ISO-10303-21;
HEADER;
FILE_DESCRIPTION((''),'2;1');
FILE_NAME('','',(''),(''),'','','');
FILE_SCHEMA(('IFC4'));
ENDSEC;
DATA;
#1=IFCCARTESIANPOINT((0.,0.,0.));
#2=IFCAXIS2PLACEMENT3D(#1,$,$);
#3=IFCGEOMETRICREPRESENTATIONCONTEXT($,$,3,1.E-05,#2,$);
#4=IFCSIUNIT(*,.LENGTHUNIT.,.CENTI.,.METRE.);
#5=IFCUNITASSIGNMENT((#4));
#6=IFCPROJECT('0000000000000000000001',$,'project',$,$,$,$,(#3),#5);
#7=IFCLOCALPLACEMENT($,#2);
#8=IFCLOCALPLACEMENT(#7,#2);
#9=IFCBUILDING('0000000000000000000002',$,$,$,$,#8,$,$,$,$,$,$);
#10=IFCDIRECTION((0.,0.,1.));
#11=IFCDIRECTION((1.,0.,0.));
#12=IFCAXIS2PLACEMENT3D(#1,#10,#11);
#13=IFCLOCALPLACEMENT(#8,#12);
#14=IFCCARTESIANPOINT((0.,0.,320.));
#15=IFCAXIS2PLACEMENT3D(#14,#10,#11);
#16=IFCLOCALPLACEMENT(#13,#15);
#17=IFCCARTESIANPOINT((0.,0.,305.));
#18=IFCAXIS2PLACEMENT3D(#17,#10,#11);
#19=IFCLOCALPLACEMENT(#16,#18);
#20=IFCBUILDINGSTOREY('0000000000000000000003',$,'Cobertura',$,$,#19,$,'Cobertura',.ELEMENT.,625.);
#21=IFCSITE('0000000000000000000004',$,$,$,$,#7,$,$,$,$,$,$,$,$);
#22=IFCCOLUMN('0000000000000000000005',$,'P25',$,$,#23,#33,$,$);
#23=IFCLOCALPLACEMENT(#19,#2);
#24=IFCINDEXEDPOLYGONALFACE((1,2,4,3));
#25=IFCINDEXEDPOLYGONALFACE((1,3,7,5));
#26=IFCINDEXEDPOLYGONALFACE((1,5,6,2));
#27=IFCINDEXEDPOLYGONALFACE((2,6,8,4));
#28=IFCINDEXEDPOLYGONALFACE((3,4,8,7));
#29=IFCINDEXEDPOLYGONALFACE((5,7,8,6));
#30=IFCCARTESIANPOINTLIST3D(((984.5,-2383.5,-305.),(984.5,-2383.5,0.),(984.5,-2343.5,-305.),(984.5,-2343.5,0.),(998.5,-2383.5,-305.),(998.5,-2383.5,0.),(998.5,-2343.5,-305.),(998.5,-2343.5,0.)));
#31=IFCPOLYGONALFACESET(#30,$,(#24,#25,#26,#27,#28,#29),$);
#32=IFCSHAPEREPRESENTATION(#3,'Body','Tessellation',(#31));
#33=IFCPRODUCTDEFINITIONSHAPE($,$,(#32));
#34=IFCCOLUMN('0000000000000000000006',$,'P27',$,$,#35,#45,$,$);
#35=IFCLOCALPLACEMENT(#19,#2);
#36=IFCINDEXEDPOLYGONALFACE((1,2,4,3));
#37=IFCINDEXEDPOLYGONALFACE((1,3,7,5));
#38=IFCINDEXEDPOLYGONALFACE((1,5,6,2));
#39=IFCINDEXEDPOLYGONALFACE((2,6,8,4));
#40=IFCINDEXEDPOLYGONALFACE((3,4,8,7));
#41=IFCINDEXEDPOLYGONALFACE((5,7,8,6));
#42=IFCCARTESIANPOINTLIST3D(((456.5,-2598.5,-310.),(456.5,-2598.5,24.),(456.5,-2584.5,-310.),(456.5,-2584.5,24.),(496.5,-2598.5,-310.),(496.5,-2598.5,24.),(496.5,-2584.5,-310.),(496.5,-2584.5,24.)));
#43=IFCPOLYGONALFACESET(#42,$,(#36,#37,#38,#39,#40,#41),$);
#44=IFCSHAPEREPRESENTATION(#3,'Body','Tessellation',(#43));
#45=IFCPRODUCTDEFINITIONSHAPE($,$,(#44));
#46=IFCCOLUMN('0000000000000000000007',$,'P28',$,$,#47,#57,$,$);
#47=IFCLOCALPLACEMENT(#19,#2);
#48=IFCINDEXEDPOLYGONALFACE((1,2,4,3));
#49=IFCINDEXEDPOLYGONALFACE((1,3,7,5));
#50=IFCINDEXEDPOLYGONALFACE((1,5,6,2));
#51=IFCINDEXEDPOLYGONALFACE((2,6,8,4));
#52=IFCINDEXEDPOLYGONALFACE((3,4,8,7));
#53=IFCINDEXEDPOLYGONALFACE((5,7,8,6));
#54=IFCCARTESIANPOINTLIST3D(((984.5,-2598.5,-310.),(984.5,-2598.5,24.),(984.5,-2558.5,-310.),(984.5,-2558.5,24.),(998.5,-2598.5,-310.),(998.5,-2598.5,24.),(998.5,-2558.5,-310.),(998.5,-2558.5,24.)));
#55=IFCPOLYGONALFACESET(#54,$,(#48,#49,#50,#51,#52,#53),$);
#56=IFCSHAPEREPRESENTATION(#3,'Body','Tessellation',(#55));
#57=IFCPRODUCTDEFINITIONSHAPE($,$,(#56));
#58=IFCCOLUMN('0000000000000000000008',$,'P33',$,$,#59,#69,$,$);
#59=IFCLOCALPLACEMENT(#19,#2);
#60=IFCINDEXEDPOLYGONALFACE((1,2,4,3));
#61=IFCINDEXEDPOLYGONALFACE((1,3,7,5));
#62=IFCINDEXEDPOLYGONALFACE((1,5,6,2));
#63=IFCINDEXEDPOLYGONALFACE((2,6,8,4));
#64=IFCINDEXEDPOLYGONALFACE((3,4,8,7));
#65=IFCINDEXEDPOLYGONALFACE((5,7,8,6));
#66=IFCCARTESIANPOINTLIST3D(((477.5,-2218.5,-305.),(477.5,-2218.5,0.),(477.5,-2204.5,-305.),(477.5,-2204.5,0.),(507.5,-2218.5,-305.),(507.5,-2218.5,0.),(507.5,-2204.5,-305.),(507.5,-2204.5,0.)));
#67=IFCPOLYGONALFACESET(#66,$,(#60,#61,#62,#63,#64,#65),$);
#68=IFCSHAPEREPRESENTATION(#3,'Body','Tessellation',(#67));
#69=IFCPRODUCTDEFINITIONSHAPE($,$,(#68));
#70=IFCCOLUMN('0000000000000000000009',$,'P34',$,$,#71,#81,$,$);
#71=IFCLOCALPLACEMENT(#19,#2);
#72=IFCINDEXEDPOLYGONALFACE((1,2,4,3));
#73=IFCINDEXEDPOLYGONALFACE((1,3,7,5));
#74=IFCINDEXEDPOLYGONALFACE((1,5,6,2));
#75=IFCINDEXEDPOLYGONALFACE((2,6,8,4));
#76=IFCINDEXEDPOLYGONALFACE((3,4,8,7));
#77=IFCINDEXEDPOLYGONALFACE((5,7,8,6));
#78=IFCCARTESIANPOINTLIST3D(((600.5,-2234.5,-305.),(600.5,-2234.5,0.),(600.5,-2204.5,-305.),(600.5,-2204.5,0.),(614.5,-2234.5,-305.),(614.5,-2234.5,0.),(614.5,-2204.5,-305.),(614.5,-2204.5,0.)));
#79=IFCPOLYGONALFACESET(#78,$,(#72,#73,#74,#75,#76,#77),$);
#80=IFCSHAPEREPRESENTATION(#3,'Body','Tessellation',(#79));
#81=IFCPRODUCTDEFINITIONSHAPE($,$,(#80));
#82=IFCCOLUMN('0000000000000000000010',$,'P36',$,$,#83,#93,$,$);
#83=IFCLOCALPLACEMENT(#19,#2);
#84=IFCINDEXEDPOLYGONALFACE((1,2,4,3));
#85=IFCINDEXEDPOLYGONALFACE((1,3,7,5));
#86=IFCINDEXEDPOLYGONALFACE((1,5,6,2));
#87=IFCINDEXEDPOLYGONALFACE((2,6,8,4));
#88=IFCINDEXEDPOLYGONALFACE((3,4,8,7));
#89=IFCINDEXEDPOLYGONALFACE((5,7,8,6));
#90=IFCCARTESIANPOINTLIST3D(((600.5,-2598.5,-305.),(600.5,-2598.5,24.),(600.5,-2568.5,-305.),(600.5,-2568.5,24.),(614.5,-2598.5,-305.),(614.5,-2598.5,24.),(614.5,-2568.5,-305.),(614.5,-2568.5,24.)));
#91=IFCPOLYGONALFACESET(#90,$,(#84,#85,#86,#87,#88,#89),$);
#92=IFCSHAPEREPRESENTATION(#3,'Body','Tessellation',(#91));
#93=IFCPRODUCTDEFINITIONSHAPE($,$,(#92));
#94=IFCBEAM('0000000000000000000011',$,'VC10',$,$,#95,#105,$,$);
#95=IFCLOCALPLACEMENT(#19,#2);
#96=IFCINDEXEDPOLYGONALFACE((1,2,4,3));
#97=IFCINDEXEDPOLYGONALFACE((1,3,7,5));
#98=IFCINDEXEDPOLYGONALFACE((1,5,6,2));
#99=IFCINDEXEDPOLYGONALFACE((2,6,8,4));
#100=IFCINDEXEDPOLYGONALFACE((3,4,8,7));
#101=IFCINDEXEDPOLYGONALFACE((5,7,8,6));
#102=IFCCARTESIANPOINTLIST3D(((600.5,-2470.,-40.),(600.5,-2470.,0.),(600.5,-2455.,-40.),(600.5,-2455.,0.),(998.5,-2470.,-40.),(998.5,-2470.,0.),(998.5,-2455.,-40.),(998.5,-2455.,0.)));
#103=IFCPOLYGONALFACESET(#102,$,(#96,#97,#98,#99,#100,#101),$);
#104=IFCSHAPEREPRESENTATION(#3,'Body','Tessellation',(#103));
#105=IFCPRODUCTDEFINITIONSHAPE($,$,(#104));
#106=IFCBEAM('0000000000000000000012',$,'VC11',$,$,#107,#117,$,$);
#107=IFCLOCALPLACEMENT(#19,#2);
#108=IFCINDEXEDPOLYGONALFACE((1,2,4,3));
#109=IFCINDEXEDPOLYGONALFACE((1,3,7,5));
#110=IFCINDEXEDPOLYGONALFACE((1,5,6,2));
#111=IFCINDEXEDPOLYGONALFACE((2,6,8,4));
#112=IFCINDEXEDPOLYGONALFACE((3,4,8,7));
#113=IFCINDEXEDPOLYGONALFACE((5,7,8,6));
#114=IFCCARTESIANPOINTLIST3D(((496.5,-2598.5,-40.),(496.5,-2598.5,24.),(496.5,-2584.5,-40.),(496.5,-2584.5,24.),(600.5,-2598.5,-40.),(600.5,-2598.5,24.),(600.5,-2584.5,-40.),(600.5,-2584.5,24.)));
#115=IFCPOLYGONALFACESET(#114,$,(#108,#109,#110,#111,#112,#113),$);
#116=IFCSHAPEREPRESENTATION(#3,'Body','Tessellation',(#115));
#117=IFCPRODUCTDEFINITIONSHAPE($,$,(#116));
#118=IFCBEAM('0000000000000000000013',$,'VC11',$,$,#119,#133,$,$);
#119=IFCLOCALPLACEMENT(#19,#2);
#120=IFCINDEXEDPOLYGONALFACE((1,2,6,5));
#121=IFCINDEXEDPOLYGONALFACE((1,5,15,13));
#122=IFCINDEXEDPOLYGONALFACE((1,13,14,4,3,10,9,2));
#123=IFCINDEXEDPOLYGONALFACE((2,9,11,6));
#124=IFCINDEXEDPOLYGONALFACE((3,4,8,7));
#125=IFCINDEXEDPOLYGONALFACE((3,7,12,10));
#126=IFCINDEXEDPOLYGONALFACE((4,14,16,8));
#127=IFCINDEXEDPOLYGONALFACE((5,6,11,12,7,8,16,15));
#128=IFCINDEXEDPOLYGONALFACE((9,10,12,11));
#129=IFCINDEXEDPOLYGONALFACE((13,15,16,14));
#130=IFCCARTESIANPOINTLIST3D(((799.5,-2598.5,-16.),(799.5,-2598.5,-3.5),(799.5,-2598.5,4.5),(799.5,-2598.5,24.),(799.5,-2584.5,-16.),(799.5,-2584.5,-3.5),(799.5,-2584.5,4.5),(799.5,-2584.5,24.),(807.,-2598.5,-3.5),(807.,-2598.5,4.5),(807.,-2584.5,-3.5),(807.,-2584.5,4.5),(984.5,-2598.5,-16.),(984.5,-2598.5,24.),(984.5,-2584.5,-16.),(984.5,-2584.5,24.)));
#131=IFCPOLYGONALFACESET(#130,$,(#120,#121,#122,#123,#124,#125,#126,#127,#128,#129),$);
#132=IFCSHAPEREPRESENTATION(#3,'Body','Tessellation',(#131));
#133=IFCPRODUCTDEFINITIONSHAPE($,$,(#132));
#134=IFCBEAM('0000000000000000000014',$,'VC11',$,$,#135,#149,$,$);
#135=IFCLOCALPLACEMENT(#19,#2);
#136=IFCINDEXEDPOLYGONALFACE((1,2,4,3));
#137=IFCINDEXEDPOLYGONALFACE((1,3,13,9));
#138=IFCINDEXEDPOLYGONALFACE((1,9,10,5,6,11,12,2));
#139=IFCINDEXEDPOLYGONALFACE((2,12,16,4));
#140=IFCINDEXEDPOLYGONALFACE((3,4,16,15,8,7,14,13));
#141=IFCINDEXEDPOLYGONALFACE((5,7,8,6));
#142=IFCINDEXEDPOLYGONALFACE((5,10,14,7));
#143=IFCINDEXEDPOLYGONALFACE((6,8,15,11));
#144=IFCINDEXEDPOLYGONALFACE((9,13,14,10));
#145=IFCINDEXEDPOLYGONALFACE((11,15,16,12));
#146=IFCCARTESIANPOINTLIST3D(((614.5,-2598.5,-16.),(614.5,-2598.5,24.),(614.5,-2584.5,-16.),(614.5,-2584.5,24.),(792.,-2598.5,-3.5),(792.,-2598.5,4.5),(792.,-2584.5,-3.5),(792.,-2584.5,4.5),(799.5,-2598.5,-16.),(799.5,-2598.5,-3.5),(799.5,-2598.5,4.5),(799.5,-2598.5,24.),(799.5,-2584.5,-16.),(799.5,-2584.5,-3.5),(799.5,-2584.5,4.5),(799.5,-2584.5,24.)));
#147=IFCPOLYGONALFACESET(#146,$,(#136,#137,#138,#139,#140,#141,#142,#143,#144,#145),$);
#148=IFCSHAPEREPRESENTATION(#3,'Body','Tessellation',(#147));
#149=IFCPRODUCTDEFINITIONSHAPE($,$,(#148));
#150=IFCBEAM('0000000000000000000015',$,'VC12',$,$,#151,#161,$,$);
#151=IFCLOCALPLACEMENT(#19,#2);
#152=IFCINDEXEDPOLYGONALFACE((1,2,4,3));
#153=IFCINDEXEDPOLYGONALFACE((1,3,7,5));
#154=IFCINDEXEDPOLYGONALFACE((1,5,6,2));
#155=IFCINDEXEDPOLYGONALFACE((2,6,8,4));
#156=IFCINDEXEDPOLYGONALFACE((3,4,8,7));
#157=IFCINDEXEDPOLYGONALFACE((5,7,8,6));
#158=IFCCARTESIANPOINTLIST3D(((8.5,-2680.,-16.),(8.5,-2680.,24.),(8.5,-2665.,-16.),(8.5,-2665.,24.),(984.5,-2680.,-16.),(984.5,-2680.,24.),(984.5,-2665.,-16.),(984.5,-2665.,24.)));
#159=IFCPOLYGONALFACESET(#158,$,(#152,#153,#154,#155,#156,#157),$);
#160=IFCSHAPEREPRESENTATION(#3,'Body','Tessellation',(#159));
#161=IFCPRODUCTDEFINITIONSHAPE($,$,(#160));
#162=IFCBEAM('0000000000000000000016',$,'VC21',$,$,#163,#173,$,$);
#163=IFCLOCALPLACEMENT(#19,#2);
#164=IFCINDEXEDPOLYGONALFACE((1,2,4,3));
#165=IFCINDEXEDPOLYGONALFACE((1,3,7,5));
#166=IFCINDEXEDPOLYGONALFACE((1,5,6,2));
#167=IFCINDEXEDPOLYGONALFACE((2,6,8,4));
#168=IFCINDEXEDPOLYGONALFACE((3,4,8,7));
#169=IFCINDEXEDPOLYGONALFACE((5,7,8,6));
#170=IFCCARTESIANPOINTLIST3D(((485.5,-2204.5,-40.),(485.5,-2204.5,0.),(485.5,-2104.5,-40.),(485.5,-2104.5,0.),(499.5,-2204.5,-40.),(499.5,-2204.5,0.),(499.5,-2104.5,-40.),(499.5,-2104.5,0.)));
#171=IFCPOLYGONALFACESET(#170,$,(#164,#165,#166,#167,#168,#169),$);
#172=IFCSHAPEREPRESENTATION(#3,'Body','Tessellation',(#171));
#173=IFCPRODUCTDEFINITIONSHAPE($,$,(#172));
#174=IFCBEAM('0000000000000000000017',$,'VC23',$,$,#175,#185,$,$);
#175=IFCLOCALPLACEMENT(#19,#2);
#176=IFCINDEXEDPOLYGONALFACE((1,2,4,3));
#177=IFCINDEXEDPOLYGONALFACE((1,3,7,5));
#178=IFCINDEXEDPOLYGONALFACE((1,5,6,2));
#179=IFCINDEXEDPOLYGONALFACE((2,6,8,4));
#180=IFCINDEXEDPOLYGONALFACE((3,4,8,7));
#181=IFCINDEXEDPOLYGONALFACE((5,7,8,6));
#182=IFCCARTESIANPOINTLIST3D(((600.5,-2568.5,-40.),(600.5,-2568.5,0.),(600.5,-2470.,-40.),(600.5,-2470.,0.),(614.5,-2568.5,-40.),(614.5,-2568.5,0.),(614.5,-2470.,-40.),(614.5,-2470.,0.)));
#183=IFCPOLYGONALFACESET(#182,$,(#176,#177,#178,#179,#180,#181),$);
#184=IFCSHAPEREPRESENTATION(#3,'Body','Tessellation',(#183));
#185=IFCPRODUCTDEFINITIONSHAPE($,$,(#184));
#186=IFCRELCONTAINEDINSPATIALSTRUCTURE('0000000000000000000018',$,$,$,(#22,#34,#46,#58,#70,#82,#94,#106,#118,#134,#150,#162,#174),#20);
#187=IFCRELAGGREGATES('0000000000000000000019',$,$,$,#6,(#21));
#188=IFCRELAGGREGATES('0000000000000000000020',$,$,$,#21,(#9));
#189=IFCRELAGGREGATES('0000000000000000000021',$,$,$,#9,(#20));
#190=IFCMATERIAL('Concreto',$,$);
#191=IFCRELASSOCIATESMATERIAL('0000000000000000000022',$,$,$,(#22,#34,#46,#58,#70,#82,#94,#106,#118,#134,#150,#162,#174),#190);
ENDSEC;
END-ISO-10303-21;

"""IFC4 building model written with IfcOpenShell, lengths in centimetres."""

from ifc_helpers import new_model, si_unit, frame, origin, origin_with_axes, place, context, project, spatial, polyline, outline, extrude, material, element, save


model = new_model("IFC4")

# Units and contexts
context_of_model = context(None, 3, precision=1e-05, world=origin())
ifc_project = project(units=[si_unit("LENGTHUNIT", "METRE", prefix="CENTI")], contexts=[context_of_model])

# Site, building, storey
site_placement = place(None, origin())
site = spatial("IfcSite", under=ifc_project, at=site_placement)
building_placement = place(site_placement, origin())
building = spatial("IfcBuilding", under=site, at=building_placement)
placement_1 = place(building_placement, origin_with_axes())
placement_2 = place(placement_1, frame((0.0, 0.0, 320.0), z_axis=(0.0, 0.0, 1.0), x_axis=(1.0, 0.0, 0.0)))
storey_placement = place(placement_2, frame((0.0, 0.0, 305.0), z_axis=(0.0, 0.0, 1.0), x_axis=(1.0, 0.0, 0.0)))
storey = spatial("IfcBuildingStorey", under=building, at=storey_placement, Name="Cobertura", LongName="Cobertura", CompositionType="ELEMENT", Elevation=625.0)

# Columns
ifc_material = material(Name="Concreto")
column_1_placement = place(storey_placement, frame((991.5, -2363.5, 0.0), z_axis=(0.0, 0.0, 1.0), x_axis=(1.0, 0.0, 0.0)))
element("IfcColumn", 1, at=column_1_placement, inside=storey, material=ifc_material, Name="P25", context=context_of_model, shape_type="SolidModel", body=[
    extrude(outline(polyline([(7.0, 20.0), (-7.0, 20.0), (-7.0, -20.0), (7.0, -20.0), (7.0, 20.0)])), origin_with_axes(), (0.0, 0.0, -1.0), 305.0),
])
column_2_placement = place(storey_placement, frame((476.5, -2591.5, 24.0), z_axis=(0.0, 0.0, 1.0), x_axis=(1.0, 0.0, 0.0)))
element("IfcColumn", 2, at=column_2_placement, inside=storey, material=ifc_material, Name="P27", context=context_of_model, shape_type="SolidModel", body=[
    extrude(outline(polyline([(20.0, -7.0), (20.0, 7.0), (-20.0, 7.0), (-20.0, -7.0), (20.0, -7.0)])), origin_with_axes(), (0.0, 0.0, -1.0), 334.0),
])
column_3_placement = place(storey_placement, frame((991.5, -2578.5, 24.0), z_axis=(0.0, 0.0, 1.0), x_axis=(1.0, 0.0, 0.0)))
element("IfcColumn", 3, at=column_3_placement, inside=storey, material=ifc_material, Name="P28", context=context_of_model, shape_type="SolidModel", body=[
    extrude(outline(polyline([(7.0, 20.0), (-7.0, 20.0), (-7.0, -20.0), (7.0, -20.0), (7.0, 20.0)])), origin_with_axes(), (0.0, 0.0, -1.0), 334.0),
])
column_4_placement = place(storey_placement, frame((492.5, -2211.5, 0.0), z_axis=(0.0, 0.0, 1.0), x_axis=(1.0, 0.0, 0.0)))
element("IfcColumn", 4, at=column_4_placement, inside=storey, material=ifc_material, Name="P33", context=context_of_model, shape_type="SolidModel", body=[
    extrude(outline(polyline([(15.0, -7.0), (15.0, 7.0), (-15.0, 7.0), (-15.0, -7.0), (15.0, -7.0)])), origin_with_axes(), (0.0, 0.0, -1.0), 305.0),
])
column_5_placement = place(storey_placement, frame((607.5, -2219.5, 0.0), z_axis=(0.0, 0.0, 1.0), x_axis=(1.0, 0.0, 0.0)))
element("IfcColumn", 5, at=column_5_placement, inside=storey, material=ifc_material, Name="P34", context=context_of_model, shape_type="SolidModel", body=[
    extrude(outline(polyline([(7.0, 15.0), (-7.0, 15.0), (-7.0, -15.0), (7.0, -15.0), (7.0, 15.0)])), origin_with_axes(), (0.0, 0.0, -1.0), 305.0),
])
column_6_placement = place(storey_placement, frame((607.5, -2583.5, 24.0), z_axis=(0.0, 0.0, 1.0), x_axis=(1.0, 0.0, 0.0)))
element("IfcColumn", 6, at=column_6_placement, inside=storey, material=ifc_material, Name="P36", context=context_of_model, shape_type="SolidModel", body=[
    extrude(outline(polyline([(7.0, 15.0), (-7.0, 15.0), (-7.0, -15.0), (7.0, -15.0), (7.0, 15.0)])), origin_with_axes(), (0.0, 0.0, -1.0), 329.0),
])

# Beams
beam_1_placement = place(storey_placement, frame((799.5, -2462.5, 0.0), z_axis=(0.0, 0.0, 1.0), x_axis=(1.0, 0.0, 0.0)))
element("IfcBeam", 7, at=beam_1_placement, inside=storey, material=ifc_material, Name="VC10", context=context_of_model, shape_type="SolidModel", body=[
    extrude(outline(polyline([(-7.5, -20.0), (7.5, -20.0), (7.5, 20.0), (-7.5, 20.0), (-7.5, -20.0)])), frame((-199.0, 0.0, -20.0), z_axis=(1.0, 0.0, 0.0), x_axis=(0.0, -1.0, 0.0)), (0.0, 0.0, 1.0), 398.0),
])
beam_2_placement = place(storey_placement, frame((548.5, -2591.5, 24.0), z_axis=(0.0, 0.0, 1.0), x_axis=(1.0, 0.0, 0.0)))
element("IfcBeam", 8, at=beam_2_placement, inside=storey, material=ifc_material, Name="VC11", context=context_of_model, shape_type="SolidModel", body=[
    extrude(outline(polyline([(-7.0, -32.0), (7.0, -32.0), (7.0, 32.0), (-7.0, 32.0), (-7.0, -32.0)])), frame((-52.0, 0.0, -32.0), z_axis=(1.0, 0.0, 0.0), x_axis=(0.0, -1.0, 0.0)), (0.0, 0.0, 1.0), 104.0),
])

# Beams, openings
beam_3_placement = place(storey_placement, frame((892.0, -2591.5, 24.0), z_axis=(0.0, 0.0, 1.0), x_axis=(1.0, 0.0, 0.0)))
beam_3 = element("IfcBeam", 9, at=beam_3_placement, inside=storey, material=ifc_material, Name="VC11", context=context_of_model, shape_type="SolidModel", body=[
    extrude(outline(polyline([(-7.0, -20.0), (7.0, -20.0), (7.0, 20.0), (-7.0, 20.0), (-7.0, -20.0)])), frame((-92.5, 0.0, -20.0), z_axis=(1.0, 0.0, 0.0), x_axis=(0.0, -1.0, 0.0)), (0.0, 0.0, 1.0), 185.0),
])
opening_1_placement = place(storey_placement, frame((0.0, 0.0, -625.0), z_axis=(0.0, 0.0, 1.0), x_axis=(1.0, 0.0, 0.0)))
element("IfcOpeningElement", 10, at=opening_1_placement, cuts=beam_3, material=ifc_material, context=context_of_model, shape_type="SweptSolid", body=[
    extrude(outline(polyline([(7.5, 4.0), (-7.5, 4.0), (-7.5, -4.0), (7.5, -4.0), (7.5, 4.0)])), frame((799.5, -2598.5, 625.5), z_axis=(0.0, 1.0, 0.0), x_axis=(-1.0, 0.0, 0.0)), (0.0, 0.0, 1.0), 14.0),
])
beam_4_placement = place(storey_placement, frame((707.0, -2591.5, 24.0), z_axis=(0.0, 0.0, 1.0), x_axis=(1.0, 0.0, 0.0)))
beam_4 = element("IfcBeam", 11, at=beam_4_placement, inside=storey, material=ifc_material, Name="VC11", context=context_of_model, shape_type="SolidModel", body=[
    extrude(outline(polyline([(-7.0, -20.0), (7.0, -20.0), (7.0, 20.0), (-7.0, 20.0), (-7.0, -20.0)])), frame((-92.5, 0.0, -20.0), z_axis=(1.0, 0.0, 0.0), x_axis=(0.0, -1.0, 0.0)), (0.0, 0.0, 1.0), 185.0),
])
opening_2_placement = place(storey_placement, frame((0.0, 0.0, -625.0), z_axis=(0.0, 0.0, 1.0), x_axis=(1.0, 0.0, 0.0)))
element("IfcOpeningElement", 12, at=opening_2_placement, cuts=beam_4, material=ifc_material, context=context_of_model, shape_type="SweptSolid", body=[
    extrude(outline(polyline([(7.5, 4.0), (-7.5, 4.0), (-7.5, -4.0), (7.5, -4.0), (7.5, 4.0)])), frame((799.5, -2598.5, 625.5), z_axis=(0.0, 1.0, 0.0), x_axis=(-1.0, 0.0, 0.0)), (0.0, 0.0, 1.0), 14.0),
])

# Beams
beam_5_placement = place(storey_placement, frame((496.5, -2672.5, 24.0), z_axis=(0.0, 0.0, 1.0), x_axis=(1.0, 0.0, 0.0)))
element("IfcBeam", 13, at=beam_5_placement, inside=storey, material=ifc_material, Name="VC12", context=context_of_model, shape_type="SolidModel", body=[
    extrude(outline(polyline([(-7.5, -20.0), (7.5, -20.0), (7.5, 20.0), (-7.5, 20.0), (-7.5, -20.0)])), frame((-488.0, 0.0, -20.0), z_axis=(1.0, 0.0, 0.0), x_axis=(0.0, -1.0, 0.0)), (0.0, 0.0, 1.0), 976.0),
])
beam_6_placement = place(storey_placement, frame((492.5, -2154.5, 0.0), z_axis=(0.0, 0.0, 1.0), x_axis=(1.0, 0.0, 0.0)))
element("IfcBeam", 14, at=beam_6_placement, inside=storey, material=ifc_material, Name="VC21", context=context_of_model, shape_type="SolidModel", body=[
    extrude(outline(polyline([(-7.0, -20.0), (7.0, -20.0), (7.0, 20.0), (-7.0, 20.0), (-7.0, -20.0)])), frame((0.0, -50.0, -20.0), z_axis=(0.0, 1.0, 0.0), x_axis=(1.0, 0.0, 0.0)), (0.0, 0.0, 1.0), 100.0),
])
beam_7_placement = place(storey_placement, frame((607.5, -2519.25, 0.0), z_axis=(0.0, 0.0, 1.0), x_axis=(1.0, 0.0, 0.0)))
element("IfcBeam", 15, at=beam_7_placement, inside=storey, material=ifc_material, Name="VC23", context=context_of_model, shape_type="SolidModel", body=[
    extrude(outline(polyline([(-7.0, -20.0), (7.0, -20.0), (7.0, 20.0), (-7.0, 20.0), (-7.0, -20.0)])), frame((0.0, -49.25, -20.0), z_axis=(0.0, 1.0, 0.0), x_axis=(1.0, 0.0, 0.0)), (0.0, 0.0, 1.0), 98.5),
])

save(model, "model.ifc")
